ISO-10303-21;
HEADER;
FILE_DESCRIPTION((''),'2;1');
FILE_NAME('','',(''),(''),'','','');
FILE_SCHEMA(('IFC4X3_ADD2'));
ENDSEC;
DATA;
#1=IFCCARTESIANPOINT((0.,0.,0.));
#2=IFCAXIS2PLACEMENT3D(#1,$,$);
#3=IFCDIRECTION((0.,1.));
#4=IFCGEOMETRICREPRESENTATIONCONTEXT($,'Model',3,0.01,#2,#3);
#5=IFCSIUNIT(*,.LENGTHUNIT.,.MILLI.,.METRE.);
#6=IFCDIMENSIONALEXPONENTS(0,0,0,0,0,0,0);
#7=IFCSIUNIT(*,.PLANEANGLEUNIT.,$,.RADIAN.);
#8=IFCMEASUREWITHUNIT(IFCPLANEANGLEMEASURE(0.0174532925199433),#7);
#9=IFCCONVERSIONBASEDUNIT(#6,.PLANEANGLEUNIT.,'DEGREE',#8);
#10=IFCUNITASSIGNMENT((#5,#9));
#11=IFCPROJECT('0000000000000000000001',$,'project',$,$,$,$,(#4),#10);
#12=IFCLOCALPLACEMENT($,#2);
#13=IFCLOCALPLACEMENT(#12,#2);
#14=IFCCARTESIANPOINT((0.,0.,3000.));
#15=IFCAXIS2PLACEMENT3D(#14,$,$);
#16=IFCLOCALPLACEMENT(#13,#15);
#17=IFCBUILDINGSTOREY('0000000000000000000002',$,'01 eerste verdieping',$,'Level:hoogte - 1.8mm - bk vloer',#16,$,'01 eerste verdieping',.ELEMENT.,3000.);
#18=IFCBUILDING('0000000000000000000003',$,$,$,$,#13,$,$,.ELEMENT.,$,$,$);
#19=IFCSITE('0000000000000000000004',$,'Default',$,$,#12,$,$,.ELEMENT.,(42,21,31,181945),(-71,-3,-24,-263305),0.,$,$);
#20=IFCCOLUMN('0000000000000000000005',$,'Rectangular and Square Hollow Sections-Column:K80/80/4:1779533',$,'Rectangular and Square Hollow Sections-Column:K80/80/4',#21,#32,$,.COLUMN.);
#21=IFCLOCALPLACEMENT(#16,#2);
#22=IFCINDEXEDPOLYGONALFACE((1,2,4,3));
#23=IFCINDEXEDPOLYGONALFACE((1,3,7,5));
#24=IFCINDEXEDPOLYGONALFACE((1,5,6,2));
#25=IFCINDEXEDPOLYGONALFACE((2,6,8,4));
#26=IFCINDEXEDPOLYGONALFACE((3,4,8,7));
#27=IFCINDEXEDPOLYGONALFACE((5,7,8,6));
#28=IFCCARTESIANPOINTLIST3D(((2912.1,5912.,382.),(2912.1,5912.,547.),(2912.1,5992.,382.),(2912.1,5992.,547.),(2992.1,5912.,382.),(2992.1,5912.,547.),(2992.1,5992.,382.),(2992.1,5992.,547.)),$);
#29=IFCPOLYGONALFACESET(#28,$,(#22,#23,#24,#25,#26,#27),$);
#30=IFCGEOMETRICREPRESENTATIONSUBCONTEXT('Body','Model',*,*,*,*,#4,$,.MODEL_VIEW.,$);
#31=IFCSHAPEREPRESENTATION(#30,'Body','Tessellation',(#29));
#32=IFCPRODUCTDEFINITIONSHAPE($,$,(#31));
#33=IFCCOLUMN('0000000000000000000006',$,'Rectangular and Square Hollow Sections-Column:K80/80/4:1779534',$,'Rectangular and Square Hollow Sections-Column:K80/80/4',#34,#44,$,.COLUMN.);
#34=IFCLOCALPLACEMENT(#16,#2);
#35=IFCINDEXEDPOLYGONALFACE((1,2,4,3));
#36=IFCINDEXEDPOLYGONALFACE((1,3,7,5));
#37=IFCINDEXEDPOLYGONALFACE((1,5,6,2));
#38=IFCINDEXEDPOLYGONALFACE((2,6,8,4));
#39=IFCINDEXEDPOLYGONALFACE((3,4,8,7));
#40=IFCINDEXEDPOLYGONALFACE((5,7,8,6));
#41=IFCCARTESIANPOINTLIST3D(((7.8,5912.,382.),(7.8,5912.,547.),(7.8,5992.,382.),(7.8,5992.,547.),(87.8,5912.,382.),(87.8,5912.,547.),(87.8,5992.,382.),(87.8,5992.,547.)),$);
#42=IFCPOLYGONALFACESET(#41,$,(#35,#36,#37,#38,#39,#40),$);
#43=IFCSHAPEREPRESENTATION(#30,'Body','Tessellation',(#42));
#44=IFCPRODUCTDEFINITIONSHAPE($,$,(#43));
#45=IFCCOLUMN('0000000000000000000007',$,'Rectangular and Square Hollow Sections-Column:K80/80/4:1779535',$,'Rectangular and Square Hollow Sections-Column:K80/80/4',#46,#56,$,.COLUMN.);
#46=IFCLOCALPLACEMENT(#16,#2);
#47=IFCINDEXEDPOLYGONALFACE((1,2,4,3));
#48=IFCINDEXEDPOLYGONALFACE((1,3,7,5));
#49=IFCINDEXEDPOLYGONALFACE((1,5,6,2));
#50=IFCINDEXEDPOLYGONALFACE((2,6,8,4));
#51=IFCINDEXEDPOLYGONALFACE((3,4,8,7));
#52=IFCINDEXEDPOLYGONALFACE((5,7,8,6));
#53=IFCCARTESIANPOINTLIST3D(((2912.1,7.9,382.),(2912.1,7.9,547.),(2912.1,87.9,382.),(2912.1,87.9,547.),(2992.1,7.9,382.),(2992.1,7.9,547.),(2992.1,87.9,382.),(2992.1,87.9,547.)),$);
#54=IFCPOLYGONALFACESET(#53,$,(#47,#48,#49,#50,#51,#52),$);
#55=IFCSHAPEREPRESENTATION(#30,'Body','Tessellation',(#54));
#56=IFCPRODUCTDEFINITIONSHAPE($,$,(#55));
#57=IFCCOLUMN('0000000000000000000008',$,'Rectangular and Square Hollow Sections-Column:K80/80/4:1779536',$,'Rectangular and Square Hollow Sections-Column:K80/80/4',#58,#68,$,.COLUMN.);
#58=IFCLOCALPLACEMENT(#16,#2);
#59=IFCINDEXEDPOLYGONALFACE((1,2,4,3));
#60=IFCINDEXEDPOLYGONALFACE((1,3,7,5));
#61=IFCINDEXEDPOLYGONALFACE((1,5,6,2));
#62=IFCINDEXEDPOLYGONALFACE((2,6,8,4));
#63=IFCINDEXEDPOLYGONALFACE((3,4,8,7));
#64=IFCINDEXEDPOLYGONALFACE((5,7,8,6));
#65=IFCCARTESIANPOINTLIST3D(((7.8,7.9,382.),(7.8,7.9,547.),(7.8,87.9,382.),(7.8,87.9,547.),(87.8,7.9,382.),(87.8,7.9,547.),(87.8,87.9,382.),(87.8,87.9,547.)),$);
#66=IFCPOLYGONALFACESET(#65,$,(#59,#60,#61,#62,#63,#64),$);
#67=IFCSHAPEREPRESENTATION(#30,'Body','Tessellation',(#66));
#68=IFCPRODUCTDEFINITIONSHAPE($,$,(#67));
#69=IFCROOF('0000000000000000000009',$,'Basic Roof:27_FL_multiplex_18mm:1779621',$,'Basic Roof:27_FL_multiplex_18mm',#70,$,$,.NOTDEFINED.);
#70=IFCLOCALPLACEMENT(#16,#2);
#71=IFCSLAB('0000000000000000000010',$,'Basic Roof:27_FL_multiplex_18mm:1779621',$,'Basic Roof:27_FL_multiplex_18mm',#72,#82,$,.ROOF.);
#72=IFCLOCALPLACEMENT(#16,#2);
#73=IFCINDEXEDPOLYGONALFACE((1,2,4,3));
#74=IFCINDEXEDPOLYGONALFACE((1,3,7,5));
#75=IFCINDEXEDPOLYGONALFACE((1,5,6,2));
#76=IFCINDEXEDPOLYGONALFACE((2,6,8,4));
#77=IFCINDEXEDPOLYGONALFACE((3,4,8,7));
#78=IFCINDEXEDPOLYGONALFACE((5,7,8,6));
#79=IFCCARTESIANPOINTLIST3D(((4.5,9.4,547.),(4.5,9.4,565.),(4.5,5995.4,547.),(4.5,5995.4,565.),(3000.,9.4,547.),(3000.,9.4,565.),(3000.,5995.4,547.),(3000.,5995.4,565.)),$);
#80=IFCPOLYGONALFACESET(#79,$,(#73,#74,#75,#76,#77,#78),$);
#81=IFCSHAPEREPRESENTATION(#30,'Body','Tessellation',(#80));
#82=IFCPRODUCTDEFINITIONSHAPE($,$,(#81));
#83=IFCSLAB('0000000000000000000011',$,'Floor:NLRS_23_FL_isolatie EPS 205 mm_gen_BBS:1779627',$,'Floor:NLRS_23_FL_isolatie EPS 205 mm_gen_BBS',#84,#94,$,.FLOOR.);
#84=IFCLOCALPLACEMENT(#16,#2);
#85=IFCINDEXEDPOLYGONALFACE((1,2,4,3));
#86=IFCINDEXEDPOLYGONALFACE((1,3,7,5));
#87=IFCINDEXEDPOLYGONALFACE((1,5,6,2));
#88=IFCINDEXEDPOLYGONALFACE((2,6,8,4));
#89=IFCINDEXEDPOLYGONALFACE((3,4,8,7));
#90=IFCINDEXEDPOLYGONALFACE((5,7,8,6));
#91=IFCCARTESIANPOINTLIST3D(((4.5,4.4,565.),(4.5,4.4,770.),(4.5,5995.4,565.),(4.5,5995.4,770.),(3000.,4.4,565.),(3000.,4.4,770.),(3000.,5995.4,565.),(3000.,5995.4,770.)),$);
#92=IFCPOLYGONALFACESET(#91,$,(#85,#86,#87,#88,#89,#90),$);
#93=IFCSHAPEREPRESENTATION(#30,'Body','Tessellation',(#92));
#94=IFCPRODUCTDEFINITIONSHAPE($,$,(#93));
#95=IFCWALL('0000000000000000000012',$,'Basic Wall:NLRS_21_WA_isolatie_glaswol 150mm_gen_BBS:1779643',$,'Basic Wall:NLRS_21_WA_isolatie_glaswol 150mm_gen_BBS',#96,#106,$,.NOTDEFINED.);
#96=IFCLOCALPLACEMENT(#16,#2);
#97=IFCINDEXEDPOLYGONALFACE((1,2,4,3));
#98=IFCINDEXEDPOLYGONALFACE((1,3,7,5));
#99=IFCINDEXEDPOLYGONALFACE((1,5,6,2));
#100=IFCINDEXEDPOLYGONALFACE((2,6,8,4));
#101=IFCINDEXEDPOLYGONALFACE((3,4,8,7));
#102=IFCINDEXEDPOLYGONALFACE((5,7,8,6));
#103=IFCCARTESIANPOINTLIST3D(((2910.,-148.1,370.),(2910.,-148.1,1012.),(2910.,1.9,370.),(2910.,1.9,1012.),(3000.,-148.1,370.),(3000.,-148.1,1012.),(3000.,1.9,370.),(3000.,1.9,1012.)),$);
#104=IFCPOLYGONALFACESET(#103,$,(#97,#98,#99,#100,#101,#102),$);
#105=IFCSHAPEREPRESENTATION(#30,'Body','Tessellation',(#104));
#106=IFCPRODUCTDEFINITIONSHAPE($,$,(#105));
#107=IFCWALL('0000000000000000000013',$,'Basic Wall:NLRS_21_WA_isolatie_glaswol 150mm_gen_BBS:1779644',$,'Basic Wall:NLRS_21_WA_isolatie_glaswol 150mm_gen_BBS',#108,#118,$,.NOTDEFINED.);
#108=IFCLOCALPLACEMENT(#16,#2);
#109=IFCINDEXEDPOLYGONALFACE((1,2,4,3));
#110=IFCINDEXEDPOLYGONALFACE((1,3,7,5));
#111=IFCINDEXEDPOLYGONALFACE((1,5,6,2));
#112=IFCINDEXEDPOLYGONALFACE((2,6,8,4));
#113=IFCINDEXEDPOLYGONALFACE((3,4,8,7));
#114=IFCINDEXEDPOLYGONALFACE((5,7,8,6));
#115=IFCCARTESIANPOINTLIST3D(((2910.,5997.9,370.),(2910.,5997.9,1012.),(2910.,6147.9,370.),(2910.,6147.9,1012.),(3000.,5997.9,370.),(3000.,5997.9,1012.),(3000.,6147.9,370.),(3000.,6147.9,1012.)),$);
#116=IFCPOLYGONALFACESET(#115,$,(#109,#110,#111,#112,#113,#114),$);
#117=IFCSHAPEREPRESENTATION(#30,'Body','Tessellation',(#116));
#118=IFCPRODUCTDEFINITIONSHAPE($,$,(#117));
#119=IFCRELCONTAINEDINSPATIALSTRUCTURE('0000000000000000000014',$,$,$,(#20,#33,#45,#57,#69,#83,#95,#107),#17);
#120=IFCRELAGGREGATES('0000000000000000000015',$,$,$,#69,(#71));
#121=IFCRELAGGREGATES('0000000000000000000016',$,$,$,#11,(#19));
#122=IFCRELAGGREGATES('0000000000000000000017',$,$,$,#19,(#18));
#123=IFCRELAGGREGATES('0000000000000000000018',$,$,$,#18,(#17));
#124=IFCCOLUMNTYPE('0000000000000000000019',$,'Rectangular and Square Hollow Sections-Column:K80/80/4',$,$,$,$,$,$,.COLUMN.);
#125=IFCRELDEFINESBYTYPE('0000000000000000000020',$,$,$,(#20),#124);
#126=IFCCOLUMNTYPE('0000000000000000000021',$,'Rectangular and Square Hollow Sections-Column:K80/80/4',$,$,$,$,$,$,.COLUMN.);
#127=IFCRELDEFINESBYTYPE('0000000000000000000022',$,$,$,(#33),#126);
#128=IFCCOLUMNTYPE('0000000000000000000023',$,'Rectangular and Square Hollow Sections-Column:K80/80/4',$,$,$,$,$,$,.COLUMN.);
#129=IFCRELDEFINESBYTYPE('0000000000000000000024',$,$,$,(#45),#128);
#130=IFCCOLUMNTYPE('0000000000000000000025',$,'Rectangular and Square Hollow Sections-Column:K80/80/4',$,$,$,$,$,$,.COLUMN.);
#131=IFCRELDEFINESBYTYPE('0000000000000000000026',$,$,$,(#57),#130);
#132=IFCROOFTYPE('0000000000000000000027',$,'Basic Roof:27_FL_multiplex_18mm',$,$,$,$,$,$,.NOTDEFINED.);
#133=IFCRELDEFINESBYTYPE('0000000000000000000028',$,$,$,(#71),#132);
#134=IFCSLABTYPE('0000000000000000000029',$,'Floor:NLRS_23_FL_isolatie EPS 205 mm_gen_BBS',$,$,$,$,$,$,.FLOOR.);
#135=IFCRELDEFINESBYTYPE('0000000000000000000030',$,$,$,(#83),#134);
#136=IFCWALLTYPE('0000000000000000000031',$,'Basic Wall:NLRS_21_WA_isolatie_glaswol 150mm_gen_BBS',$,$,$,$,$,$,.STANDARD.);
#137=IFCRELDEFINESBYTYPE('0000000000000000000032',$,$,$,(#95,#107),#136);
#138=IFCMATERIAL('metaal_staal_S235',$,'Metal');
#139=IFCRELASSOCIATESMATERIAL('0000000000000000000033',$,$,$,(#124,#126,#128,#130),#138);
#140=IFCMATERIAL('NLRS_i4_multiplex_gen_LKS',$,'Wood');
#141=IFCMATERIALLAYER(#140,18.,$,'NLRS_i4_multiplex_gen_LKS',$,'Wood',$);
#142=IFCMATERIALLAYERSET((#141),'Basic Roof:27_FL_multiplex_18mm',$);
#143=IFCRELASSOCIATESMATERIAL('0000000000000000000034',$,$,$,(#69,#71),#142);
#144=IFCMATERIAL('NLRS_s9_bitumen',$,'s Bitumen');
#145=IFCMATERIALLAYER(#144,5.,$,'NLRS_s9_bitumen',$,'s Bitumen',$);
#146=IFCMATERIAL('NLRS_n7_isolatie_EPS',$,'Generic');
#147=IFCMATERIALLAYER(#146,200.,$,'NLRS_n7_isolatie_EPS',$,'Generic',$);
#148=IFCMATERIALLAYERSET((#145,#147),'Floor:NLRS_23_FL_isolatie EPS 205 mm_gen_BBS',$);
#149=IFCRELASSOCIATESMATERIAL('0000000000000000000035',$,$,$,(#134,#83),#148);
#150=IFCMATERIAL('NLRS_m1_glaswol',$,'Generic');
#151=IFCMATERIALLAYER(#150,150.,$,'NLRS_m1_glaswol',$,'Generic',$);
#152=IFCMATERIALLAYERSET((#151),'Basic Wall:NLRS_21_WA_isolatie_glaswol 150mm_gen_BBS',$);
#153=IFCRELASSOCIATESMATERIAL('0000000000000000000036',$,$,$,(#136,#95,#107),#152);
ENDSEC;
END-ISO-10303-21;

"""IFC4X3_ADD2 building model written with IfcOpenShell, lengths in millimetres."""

from ifc_helpers import new_model, entity, si_unit, converted_unit, direction, frame, frame_2d, origin, place, context, subcontext, project, spatial, polyline, rectangle, extrude, clip, bounded_halfspace, source, transform, mapped, material, layer, layer_set, layer_usage, material_profile, profile_set, type_object, type_shapes, element, aggregate, save


model = new_model("IFC4X3_ADD2")

# Units and contexts
model_context = context("Model", 3, precision=0.01, world=origin(), true_north=direction((0.0, 1.0)))
body_context = subcontext(model_context, "Body", "Model", "MODEL_VIEW")
ifc_project = project(units=[si_unit("LENGTHUNIT", "METRE", prefix="MILLI"), converted_unit("PLANEANGLEUNIT", "DEGREE", entity("IfcPlaneAngleMeasure", 0.0174532925199433), si_unit("PLANEANGLEUNIT", "RADIAN"), dimensions=[0, 0, 0, 0, 0, 0, 0])], contexts=[model_context])

# Site, building, storey
site_placement = place(None, origin())
site = spatial("IfcSite", under=ifc_project, at=site_placement, Name="Default", CompositionType="ELEMENT", RefLatitude=(42, 21, 31, 181945), RefLongitude=(-71, -3, -24, -263305), RefElevation=0.0)
building_placement = place(site_placement, origin())
building = spatial("IfcBuilding", under=site, at=building_placement, CompositionType="ELEMENT")
storey_placement = place(building_placement, frame((0.0, 0.0, 3000.0)))
storey = spatial("IfcBuildingStorey", under=building, at=storey_placement, Name="01 eerste verdieping", ObjectType="Level:hoogte - 1.8mm - bk vloer", LongName="01 eerste verdieping", CompositionType="ELEMENT", Elevation=3000.0)

# Columns, openings
ifc_material_1 = material(Name="metaal_staal_S235", Category="Metal")
ifc_material_profile = material_profile(ifc_material_1, rectangle(XDim=220.0, YDim=80.0, at=frame_2d((0.0, 0.0), x_axis=(1.0, 0.0))), Name="K80/80/4")
ifc_profile_set = profile_set([ifc_material_profile], Name="K80/80/4")
column_type_1 = type_object("IfcColumnType", Name="Rectangular and Square Hollow Sections-Column:K80/80/4", PredefinedType="COLUMN", material=ifc_profile_set)
shared_shape_1 = source(origin(), body_context, "Body", "SweptSolid", [
    extrude(rectangle(XDim=165.0, YDim=80.0, at=frame_2d((0.0, 0.0), x_axis=(1.0, 0.0))), frame((0.0, 40.0, 82.5), z_axis=(1.0, 0.0, 0.0), x_axis=(0.0, 0.0, -1.0)), (0.0, 0.0, 1.0), 80.0),
])
type_shapes(column_type_1, [shared_shape_1])
column_1_placement = place(storey_placement, frame((2912.1, 5912.0, 382.0)))
column_1 = element("IfcColumn", 1, at=column_1_placement, inside=storey, type_object=column_type_1, Name="Rectangular and Square Hollow Sections-Column:K80/80/4:1779533", ObjectType="Rectangular and Square Hollow Sections-Column:K80/80/4", PredefinedType="COLUMN", context=body_context, shape_type="MappedRepresentation", body=[
    mapped(shared_shape_1, transform((0.0, 0.0, 0.0), scale=1.0)),
])
opening_1_placement = place(storey_placement, frame((2912.1, 5912.0, 382.0)))
element("IfcOpeningElement", 2, at=opening_1_placement, cuts=column_1, PredefinedType="OPENING", context=body_context, shape_type="SweptSolid", body=[
    extrude(rectangle(XDim=72.0, YDim=72.0, at=frame_2d((0.0, 0.0), x_axis=(1.0, 0.0))), frame((40.0, 40.0, -3000.0), z_axis=(0.0, 0.0, 1.0), x_axis=(-1.0, 0.0, 0.0)), (0.0, 0.0, 1.0), 165.0),
])
column_type_2 = type_object("IfcColumnType", Name="Rectangular and Square Hollow Sections-Column:K80/80/4", PredefinedType="COLUMN", material=ifc_profile_set)
shared_shape_2 = source(origin(), body_context, "Body", "SweptSolid", [
    extrude(rectangle(XDim=165.0, YDim=80.0, at=frame_2d((0.0, 0.0), x_axis=(0.0, 1.0))), frame((0.0, 40.0, 82.5), z_axis=(1.0, 0.0, 0.0), x_axis=(0.0, -1.0, 0.0)), (0.0, 0.0, 1.0), 80.0),
])
type_shapes(column_type_2, [shared_shape_2])
column_2_placement = place(storey_placement, frame((7.8, 5912.0, 382.0)))
column_2 = element("IfcColumn", 3, at=column_2_placement, inside=storey, type_object=column_type_2, Name="Rectangular and Square Hollow Sections-Column:K80/80/4:1779534", ObjectType="Rectangular and Square Hollow Sections-Column:K80/80/4", PredefinedType="COLUMN", context=body_context, shape_type="MappedRepresentation", body=[
    mapped(shared_shape_2, transform((0.0, 0.0, 0.0), scale=1.0)),
])
opening_2_placement = place(storey_placement, frame((7.8, 5912.0, 382.0)))
element("IfcOpeningElement", 4, at=opening_2_placement, cuts=column_2, PredefinedType="OPENING", context=body_context, shape_type="SweptSolid", body=[
    extrude(rectangle(XDim=72.0, YDim=72.0, at=frame_2d((0.0, 0.0), x_axis=(1.0, 0.0))), frame((40.0, 40.0, -3000.0), z_axis=(0.0, 0.0, 1.0), x_axis=(0.0, -1.0, 0.0)), (0.0, 0.0, 1.0), 165.0),
])
column_type_3 = type_object("IfcColumnType", Name="Rectangular and Square Hollow Sections-Column:K80/80/4", PredefinedType="COLUMN", material=ifc_profile_set)
shared_shape_3 = source(origin(), body_context, "Body", "SweptSolid", [
    extrude(rectangle(XDim=165.0, YDim=80.0, at=frame_2d((0.0, 0.0), x_axis=(0.0, 1.0))), frame((0.0, 40.0, 82.5), z_axis=(1.0, 0.0, 0.0), x_axis=(0.0, -1.0, 0.0)), (0.0, 0.0, 1.0), 80.0),
])
type_shapes(column_type_3, [shared_shape_3])
column_3_placement = place(storey_placement, frame((2912.1, 7.9, 382.0)))
column_3 = element("IfcColumn", 5, at=column_3_placement, inside=storey, type_object=column_type_3, Name="Rectangular and Square Hollow Sections-Column:K80/80/4:1779535", ObjectType="Rectangular and Square Hollow Sections-Column:K80/80/4", PredefinedType="COLUMN", context=body_context, shape_type="MappedRepresentation", body=[
    mapped(shared_shape_3, transform((0.0, 0.0, 0.0), scale=1.0)),
])
opening_3_placement = place(storey_placement, frame((2912.1, 7.9, 382.0)))
element("IfcOpeningElement", 6, at=opening_3_placement, cuts=column_3, PredefinedType="OPENING", context=body_context, shape_type="SweptSolid", body=[
    extrude(rectangle(XDim=72.0, YDim=72.0, at=frame_2d((0.0, 0.0), x_axis=(1.0, 0.0))), frame((40.0, 40.0, -3000.0), z_axis=(0.0, 0.0, 1.0), x_axis=(0.0, 1.0, 0.0)), (0.0, 0.0, 1.0), 165.0),
])
column_type_4 = type_object("IfcColumnType", Name="Rectangular and Square Hollow Sections-Column:K80/80/4", PredefinedType="COLUMN", material=ifc_profile_set)
shared_shape_4 = source(origin(), body_context, "Body", "SweptSolid", [
    extrude(rectangle(XDim=165.0, YDim=80.0, at=frame_2d((0.0, 0.0), x_axis=(1.0, 0.0))), frame((0.0, 40.0, 82.5), z_axis=(1.0, 0.0, 0.0), x_axis=(0.0, 0.0, -1.0)), (0.0, 0.0, 1.0), 80.0),
])
type_shapes(column_type_4, [shared_shape_4])
column_4_placement = place(storey_placement, frame((7.8, 7.9, 382.0)))
column_4 = element("IfcColumn", 7, at=column_4_placement, inside=storey, type_object=column_type_4, Name="Rectangular and Square Hollow Sections-Column:K80/80/4:1779536", ObjectType="Rectangular and Square Hollow Sections-Column:K80/80/4", PredefinedType="COLUMN", context=body_context, shape_type="MappedRepresentation", body=[
    mapped(shared_shape_4, transform((0.0, 0.0, 0.0), scale=1.0)),
])
opening_4_placement = place(storey_placement, frame((7.8, 7.9, 382.0)))
element("IfcOpeningElement", 8, at=opening_4_placement, cuts=column_4, PredefinedType="OPENING", context=body_context, shape_type="SweptSolid", body=[
    extrude(rectangle(XDim=72.0, YDim=72.0, at=frame_2d((0.0, 0.0), x_axis=(1.0, 0.0))), frame((40.0, 40.0, -2835.0), z_axis=(0.0, 0.0, -1.0), x_axis=(0.0, 1.0, 0.0)), (0.0, 0.0, 1.0), 165.0),
])

# Roof, slab
ifc_material_2 = material(Name="NLRS_i4_multiplex_gen_LKS", Category="Wood")
ifc_layer_1 = layer(ifc_material_2, 18.0, Name="NLRS_i4_multiplex_gen_LKS", Category="Wood")
ifc_layer_set_1 = layer_set([ifc_layer_1], Name="Basic Roof:27_FL_multiplex_18mm")
roof_placement = place(storey_placement, frame((4.5, 9.4, 547.0)))
roof = element("IfcRoof", 9, at=roof_placement, inside=storey, material=ifc_layer_set_1, Name="Basic Roof:27_FL_multiplex_18mm:1779621", ObjectType="Basic Roof:27_FL_multiplex_18mm", PredefinedType="NOTDEFINED")
roof_type = type_object("IfcRoofType", Name="Basic Roof:27_FL_multiplex_18mm", PredefinedType="NOTDEFINED")
slab_1_placement = place(roof_placement, origin())
slab_1 = element("IfcSlab", 10, at=slab_1_placement, type_object=roof_type, material=ifc_layer_set_1, Name="Basic Roof:27_FL_multiplex_18mm:1779621", ObjectType="Basic Roof:27_FL_multiplex_18mm", PredefinedType="ROOF", context=body_context, shape_type="SweptSolid", body=[
    extrude(rectangle(XDim=2995.5, YDim=5986.0, at=frame_2d((0.0, 0.0), x_axis=(1.0, 0.0))), frame((1497.8, 2993.0, 0.0)), (0.0, 0.0, 1.0), 18.0),
])
aggregate(roof, [slab_1])

# Slab
ifc_material_3 = material(Name="NLRS_s9_bitumen", Category="s Bitumen")
ifc_layer_2 = layer(ifc_material_3, 5.0, Name="NLRS_s9_bitumen", Category="s Bitumen")
ifc_material_4 = material(Name="NLRS_n7_isolatie_EPS", Category="Generic")
ifc_layer_3 = layer(ifc_material_4, 200.0, Name="NLRS_n7_isolatie_EPS", Category="Generic")
ifc_layer_set_2 = layer_set([ifc_layer_2, ifc_layer_3], Name="Floor:NLRS_23_FL_isolatie EPS 205 mm_gen_BBS")
ifc_layer_usage_1 = layer_usage(ifc_layer_set_2, "AXIS3", "POSITIVE", 0.0)
slab_type = type_object("IfcSlabType", Name="Floor:NLRS_23_FL_isolatie EPS 205 mm_gen_BBS", PredefinedType="FLOOR", material=ifc_layer_set_2)
slab_2_placement = place(storey_placement, origin())
element("IfcSlab", 11, at=slab_2_placement, inside=storey, type_object=slab_type, material=ifc_layer_usage_1, Name="Floor:NLRS_23_FL_isolatie EPS 205 mm_gen_BBS:1779627", ObjectType="Floor:NLRS_23_FL_isolatie EPS 205 mm_gen_BBS", PredefinedType="FLOOR", context=body_context, shape_type="SweptSolid", body=[
    extrude(rectangle(XDim=5991.0, YDim=2995.5, at=frame_2d((0.0, 0.0), x_axis=(1.0, 0.0))), frame((1502.2, 2999.9, 770.0), z_axis=(0.0, 0.0, -1.0), x_axis=(0.0, 1.0, 0.0)), (0.0, 0.0, 1.0), 205.0),
])

# Walls
ifc_material_5 = material(Name="NLRS_m1_glaswol", Category="Generic")
ifc_layer_4 = layer(ifc_material_5, 150.0, Name="NLRS_m1_glaswol", Category="Generic")
ifc_layer_set_3 = layer_set([ifc_layer_4], Name="Basic Wall:NLRS_21_WA_isolatie_glaswol 150mm_gen_BBS")
ifc_layer_usage_2 = layer_usage(ifc_layer_set_3, "AXIS2", "NEGATIVE", 75.0)
wall_type = type_object("IfcWallType", Name="Basic Wall:NLRS_21_WA_isolatie_glaswol 150mm_gen_BBS", PredefinedType="STANDARD", material=ifc_layer_set_3)
wall_1_placement = place(storey_placement, frame((3000.0, -73.1, 370.0), z_axis=(0.0, 0.0, 1.0), x_axis=(-1.0, 0.0, 0.0)))
element("IfcWall", 12, at=wall_1_placement, inside=storey, type_object=wall_type, material=ifc_layer_usage_2, Name="Basic Wall:NLRS_21_WA_isolatie_glaswol 150mm_gen_BBS:1779643", ObjectType="Basic Wall:NLRS_21_WA_isolatie_glaswol 150mm_gen_BBS", PredefinedType="NOTDEFINED", context=body_context, shape_type="Clipping", body=[
    clip(extrude(rectangle(XDim=90.0, YDim=150.0, at=frame_2d((45.0, 0.0), x_axis=(-1.0, 0.0))), origin(), (0.0, 0.0, 1.0), 642.0), bounded_halfspace(frame((90.0, -75.0, 0.0), z_axis=(0.0, 0.0, 1.0), x_axis=(0.0, -1.0, 0.0)), True, frame((90.0, -75.0, 0.0), z_axis=(0.0, 0.0, 1.0), x_axis=(0.0, -1.0, 0.0)), polyline([(0.0, 0.0), (-150.0, 0.0), (-150.0, -90.0), (0.0, -90.0), (0.0, 0.0)]))),
])
ifc_layer_usage_3 = layer_usage(ifc_layer_set_3, "AXIS2", "POSITIVE", -75.0)
wall_2_placement = place(storey_placement, frame((3000.0, 6072.9, 370.0), z_axis=(0.0, 0.0, 1.0), x_axis=(-1.0, 0.0, 0.0)))
element("IfcWall", 13, at=wall_2_placement, inside=storey, type_object=wall_type, material=ifc_layer_usage_3, Name="Basic Wall:NLRS_21_WA_isolatie_glaswol 150mm_gen_BBS:1779644", ObjectType="Basic Wall:NLRS_21_WA_isolatie_glaswol 150mm_gen_BBS", PredefinedType="NOTDEFINED", context=body_context, shape_type="Clipping", body=[
    clip(extrude(rectangle(XDim=90.0, YDim=150.0, at=frame_2d((45.0, 0.0), x_axis=(-1.0, 0.0))), origin(), (0.0, 0.0, 1.0), 642.0), bounded_halfspace(frame((90.0, -75.0, 0.0), z_axis=(0.0, 0.0, 1.0), x_axis=(0.0, -1.0, 0.0)), True, frame((90.0, -75.0, 0.0), z_axis=(0.0, 0.0, 1.0), x_axis=(0.0, -1.0, 0.0)), polyline([(0.0, 0.0), (-150.0, 0.0), (-150.0, -90.0), (0.0, -90.0), (0.0, 0.0)]))),
])

save(model, "model.ifc")
